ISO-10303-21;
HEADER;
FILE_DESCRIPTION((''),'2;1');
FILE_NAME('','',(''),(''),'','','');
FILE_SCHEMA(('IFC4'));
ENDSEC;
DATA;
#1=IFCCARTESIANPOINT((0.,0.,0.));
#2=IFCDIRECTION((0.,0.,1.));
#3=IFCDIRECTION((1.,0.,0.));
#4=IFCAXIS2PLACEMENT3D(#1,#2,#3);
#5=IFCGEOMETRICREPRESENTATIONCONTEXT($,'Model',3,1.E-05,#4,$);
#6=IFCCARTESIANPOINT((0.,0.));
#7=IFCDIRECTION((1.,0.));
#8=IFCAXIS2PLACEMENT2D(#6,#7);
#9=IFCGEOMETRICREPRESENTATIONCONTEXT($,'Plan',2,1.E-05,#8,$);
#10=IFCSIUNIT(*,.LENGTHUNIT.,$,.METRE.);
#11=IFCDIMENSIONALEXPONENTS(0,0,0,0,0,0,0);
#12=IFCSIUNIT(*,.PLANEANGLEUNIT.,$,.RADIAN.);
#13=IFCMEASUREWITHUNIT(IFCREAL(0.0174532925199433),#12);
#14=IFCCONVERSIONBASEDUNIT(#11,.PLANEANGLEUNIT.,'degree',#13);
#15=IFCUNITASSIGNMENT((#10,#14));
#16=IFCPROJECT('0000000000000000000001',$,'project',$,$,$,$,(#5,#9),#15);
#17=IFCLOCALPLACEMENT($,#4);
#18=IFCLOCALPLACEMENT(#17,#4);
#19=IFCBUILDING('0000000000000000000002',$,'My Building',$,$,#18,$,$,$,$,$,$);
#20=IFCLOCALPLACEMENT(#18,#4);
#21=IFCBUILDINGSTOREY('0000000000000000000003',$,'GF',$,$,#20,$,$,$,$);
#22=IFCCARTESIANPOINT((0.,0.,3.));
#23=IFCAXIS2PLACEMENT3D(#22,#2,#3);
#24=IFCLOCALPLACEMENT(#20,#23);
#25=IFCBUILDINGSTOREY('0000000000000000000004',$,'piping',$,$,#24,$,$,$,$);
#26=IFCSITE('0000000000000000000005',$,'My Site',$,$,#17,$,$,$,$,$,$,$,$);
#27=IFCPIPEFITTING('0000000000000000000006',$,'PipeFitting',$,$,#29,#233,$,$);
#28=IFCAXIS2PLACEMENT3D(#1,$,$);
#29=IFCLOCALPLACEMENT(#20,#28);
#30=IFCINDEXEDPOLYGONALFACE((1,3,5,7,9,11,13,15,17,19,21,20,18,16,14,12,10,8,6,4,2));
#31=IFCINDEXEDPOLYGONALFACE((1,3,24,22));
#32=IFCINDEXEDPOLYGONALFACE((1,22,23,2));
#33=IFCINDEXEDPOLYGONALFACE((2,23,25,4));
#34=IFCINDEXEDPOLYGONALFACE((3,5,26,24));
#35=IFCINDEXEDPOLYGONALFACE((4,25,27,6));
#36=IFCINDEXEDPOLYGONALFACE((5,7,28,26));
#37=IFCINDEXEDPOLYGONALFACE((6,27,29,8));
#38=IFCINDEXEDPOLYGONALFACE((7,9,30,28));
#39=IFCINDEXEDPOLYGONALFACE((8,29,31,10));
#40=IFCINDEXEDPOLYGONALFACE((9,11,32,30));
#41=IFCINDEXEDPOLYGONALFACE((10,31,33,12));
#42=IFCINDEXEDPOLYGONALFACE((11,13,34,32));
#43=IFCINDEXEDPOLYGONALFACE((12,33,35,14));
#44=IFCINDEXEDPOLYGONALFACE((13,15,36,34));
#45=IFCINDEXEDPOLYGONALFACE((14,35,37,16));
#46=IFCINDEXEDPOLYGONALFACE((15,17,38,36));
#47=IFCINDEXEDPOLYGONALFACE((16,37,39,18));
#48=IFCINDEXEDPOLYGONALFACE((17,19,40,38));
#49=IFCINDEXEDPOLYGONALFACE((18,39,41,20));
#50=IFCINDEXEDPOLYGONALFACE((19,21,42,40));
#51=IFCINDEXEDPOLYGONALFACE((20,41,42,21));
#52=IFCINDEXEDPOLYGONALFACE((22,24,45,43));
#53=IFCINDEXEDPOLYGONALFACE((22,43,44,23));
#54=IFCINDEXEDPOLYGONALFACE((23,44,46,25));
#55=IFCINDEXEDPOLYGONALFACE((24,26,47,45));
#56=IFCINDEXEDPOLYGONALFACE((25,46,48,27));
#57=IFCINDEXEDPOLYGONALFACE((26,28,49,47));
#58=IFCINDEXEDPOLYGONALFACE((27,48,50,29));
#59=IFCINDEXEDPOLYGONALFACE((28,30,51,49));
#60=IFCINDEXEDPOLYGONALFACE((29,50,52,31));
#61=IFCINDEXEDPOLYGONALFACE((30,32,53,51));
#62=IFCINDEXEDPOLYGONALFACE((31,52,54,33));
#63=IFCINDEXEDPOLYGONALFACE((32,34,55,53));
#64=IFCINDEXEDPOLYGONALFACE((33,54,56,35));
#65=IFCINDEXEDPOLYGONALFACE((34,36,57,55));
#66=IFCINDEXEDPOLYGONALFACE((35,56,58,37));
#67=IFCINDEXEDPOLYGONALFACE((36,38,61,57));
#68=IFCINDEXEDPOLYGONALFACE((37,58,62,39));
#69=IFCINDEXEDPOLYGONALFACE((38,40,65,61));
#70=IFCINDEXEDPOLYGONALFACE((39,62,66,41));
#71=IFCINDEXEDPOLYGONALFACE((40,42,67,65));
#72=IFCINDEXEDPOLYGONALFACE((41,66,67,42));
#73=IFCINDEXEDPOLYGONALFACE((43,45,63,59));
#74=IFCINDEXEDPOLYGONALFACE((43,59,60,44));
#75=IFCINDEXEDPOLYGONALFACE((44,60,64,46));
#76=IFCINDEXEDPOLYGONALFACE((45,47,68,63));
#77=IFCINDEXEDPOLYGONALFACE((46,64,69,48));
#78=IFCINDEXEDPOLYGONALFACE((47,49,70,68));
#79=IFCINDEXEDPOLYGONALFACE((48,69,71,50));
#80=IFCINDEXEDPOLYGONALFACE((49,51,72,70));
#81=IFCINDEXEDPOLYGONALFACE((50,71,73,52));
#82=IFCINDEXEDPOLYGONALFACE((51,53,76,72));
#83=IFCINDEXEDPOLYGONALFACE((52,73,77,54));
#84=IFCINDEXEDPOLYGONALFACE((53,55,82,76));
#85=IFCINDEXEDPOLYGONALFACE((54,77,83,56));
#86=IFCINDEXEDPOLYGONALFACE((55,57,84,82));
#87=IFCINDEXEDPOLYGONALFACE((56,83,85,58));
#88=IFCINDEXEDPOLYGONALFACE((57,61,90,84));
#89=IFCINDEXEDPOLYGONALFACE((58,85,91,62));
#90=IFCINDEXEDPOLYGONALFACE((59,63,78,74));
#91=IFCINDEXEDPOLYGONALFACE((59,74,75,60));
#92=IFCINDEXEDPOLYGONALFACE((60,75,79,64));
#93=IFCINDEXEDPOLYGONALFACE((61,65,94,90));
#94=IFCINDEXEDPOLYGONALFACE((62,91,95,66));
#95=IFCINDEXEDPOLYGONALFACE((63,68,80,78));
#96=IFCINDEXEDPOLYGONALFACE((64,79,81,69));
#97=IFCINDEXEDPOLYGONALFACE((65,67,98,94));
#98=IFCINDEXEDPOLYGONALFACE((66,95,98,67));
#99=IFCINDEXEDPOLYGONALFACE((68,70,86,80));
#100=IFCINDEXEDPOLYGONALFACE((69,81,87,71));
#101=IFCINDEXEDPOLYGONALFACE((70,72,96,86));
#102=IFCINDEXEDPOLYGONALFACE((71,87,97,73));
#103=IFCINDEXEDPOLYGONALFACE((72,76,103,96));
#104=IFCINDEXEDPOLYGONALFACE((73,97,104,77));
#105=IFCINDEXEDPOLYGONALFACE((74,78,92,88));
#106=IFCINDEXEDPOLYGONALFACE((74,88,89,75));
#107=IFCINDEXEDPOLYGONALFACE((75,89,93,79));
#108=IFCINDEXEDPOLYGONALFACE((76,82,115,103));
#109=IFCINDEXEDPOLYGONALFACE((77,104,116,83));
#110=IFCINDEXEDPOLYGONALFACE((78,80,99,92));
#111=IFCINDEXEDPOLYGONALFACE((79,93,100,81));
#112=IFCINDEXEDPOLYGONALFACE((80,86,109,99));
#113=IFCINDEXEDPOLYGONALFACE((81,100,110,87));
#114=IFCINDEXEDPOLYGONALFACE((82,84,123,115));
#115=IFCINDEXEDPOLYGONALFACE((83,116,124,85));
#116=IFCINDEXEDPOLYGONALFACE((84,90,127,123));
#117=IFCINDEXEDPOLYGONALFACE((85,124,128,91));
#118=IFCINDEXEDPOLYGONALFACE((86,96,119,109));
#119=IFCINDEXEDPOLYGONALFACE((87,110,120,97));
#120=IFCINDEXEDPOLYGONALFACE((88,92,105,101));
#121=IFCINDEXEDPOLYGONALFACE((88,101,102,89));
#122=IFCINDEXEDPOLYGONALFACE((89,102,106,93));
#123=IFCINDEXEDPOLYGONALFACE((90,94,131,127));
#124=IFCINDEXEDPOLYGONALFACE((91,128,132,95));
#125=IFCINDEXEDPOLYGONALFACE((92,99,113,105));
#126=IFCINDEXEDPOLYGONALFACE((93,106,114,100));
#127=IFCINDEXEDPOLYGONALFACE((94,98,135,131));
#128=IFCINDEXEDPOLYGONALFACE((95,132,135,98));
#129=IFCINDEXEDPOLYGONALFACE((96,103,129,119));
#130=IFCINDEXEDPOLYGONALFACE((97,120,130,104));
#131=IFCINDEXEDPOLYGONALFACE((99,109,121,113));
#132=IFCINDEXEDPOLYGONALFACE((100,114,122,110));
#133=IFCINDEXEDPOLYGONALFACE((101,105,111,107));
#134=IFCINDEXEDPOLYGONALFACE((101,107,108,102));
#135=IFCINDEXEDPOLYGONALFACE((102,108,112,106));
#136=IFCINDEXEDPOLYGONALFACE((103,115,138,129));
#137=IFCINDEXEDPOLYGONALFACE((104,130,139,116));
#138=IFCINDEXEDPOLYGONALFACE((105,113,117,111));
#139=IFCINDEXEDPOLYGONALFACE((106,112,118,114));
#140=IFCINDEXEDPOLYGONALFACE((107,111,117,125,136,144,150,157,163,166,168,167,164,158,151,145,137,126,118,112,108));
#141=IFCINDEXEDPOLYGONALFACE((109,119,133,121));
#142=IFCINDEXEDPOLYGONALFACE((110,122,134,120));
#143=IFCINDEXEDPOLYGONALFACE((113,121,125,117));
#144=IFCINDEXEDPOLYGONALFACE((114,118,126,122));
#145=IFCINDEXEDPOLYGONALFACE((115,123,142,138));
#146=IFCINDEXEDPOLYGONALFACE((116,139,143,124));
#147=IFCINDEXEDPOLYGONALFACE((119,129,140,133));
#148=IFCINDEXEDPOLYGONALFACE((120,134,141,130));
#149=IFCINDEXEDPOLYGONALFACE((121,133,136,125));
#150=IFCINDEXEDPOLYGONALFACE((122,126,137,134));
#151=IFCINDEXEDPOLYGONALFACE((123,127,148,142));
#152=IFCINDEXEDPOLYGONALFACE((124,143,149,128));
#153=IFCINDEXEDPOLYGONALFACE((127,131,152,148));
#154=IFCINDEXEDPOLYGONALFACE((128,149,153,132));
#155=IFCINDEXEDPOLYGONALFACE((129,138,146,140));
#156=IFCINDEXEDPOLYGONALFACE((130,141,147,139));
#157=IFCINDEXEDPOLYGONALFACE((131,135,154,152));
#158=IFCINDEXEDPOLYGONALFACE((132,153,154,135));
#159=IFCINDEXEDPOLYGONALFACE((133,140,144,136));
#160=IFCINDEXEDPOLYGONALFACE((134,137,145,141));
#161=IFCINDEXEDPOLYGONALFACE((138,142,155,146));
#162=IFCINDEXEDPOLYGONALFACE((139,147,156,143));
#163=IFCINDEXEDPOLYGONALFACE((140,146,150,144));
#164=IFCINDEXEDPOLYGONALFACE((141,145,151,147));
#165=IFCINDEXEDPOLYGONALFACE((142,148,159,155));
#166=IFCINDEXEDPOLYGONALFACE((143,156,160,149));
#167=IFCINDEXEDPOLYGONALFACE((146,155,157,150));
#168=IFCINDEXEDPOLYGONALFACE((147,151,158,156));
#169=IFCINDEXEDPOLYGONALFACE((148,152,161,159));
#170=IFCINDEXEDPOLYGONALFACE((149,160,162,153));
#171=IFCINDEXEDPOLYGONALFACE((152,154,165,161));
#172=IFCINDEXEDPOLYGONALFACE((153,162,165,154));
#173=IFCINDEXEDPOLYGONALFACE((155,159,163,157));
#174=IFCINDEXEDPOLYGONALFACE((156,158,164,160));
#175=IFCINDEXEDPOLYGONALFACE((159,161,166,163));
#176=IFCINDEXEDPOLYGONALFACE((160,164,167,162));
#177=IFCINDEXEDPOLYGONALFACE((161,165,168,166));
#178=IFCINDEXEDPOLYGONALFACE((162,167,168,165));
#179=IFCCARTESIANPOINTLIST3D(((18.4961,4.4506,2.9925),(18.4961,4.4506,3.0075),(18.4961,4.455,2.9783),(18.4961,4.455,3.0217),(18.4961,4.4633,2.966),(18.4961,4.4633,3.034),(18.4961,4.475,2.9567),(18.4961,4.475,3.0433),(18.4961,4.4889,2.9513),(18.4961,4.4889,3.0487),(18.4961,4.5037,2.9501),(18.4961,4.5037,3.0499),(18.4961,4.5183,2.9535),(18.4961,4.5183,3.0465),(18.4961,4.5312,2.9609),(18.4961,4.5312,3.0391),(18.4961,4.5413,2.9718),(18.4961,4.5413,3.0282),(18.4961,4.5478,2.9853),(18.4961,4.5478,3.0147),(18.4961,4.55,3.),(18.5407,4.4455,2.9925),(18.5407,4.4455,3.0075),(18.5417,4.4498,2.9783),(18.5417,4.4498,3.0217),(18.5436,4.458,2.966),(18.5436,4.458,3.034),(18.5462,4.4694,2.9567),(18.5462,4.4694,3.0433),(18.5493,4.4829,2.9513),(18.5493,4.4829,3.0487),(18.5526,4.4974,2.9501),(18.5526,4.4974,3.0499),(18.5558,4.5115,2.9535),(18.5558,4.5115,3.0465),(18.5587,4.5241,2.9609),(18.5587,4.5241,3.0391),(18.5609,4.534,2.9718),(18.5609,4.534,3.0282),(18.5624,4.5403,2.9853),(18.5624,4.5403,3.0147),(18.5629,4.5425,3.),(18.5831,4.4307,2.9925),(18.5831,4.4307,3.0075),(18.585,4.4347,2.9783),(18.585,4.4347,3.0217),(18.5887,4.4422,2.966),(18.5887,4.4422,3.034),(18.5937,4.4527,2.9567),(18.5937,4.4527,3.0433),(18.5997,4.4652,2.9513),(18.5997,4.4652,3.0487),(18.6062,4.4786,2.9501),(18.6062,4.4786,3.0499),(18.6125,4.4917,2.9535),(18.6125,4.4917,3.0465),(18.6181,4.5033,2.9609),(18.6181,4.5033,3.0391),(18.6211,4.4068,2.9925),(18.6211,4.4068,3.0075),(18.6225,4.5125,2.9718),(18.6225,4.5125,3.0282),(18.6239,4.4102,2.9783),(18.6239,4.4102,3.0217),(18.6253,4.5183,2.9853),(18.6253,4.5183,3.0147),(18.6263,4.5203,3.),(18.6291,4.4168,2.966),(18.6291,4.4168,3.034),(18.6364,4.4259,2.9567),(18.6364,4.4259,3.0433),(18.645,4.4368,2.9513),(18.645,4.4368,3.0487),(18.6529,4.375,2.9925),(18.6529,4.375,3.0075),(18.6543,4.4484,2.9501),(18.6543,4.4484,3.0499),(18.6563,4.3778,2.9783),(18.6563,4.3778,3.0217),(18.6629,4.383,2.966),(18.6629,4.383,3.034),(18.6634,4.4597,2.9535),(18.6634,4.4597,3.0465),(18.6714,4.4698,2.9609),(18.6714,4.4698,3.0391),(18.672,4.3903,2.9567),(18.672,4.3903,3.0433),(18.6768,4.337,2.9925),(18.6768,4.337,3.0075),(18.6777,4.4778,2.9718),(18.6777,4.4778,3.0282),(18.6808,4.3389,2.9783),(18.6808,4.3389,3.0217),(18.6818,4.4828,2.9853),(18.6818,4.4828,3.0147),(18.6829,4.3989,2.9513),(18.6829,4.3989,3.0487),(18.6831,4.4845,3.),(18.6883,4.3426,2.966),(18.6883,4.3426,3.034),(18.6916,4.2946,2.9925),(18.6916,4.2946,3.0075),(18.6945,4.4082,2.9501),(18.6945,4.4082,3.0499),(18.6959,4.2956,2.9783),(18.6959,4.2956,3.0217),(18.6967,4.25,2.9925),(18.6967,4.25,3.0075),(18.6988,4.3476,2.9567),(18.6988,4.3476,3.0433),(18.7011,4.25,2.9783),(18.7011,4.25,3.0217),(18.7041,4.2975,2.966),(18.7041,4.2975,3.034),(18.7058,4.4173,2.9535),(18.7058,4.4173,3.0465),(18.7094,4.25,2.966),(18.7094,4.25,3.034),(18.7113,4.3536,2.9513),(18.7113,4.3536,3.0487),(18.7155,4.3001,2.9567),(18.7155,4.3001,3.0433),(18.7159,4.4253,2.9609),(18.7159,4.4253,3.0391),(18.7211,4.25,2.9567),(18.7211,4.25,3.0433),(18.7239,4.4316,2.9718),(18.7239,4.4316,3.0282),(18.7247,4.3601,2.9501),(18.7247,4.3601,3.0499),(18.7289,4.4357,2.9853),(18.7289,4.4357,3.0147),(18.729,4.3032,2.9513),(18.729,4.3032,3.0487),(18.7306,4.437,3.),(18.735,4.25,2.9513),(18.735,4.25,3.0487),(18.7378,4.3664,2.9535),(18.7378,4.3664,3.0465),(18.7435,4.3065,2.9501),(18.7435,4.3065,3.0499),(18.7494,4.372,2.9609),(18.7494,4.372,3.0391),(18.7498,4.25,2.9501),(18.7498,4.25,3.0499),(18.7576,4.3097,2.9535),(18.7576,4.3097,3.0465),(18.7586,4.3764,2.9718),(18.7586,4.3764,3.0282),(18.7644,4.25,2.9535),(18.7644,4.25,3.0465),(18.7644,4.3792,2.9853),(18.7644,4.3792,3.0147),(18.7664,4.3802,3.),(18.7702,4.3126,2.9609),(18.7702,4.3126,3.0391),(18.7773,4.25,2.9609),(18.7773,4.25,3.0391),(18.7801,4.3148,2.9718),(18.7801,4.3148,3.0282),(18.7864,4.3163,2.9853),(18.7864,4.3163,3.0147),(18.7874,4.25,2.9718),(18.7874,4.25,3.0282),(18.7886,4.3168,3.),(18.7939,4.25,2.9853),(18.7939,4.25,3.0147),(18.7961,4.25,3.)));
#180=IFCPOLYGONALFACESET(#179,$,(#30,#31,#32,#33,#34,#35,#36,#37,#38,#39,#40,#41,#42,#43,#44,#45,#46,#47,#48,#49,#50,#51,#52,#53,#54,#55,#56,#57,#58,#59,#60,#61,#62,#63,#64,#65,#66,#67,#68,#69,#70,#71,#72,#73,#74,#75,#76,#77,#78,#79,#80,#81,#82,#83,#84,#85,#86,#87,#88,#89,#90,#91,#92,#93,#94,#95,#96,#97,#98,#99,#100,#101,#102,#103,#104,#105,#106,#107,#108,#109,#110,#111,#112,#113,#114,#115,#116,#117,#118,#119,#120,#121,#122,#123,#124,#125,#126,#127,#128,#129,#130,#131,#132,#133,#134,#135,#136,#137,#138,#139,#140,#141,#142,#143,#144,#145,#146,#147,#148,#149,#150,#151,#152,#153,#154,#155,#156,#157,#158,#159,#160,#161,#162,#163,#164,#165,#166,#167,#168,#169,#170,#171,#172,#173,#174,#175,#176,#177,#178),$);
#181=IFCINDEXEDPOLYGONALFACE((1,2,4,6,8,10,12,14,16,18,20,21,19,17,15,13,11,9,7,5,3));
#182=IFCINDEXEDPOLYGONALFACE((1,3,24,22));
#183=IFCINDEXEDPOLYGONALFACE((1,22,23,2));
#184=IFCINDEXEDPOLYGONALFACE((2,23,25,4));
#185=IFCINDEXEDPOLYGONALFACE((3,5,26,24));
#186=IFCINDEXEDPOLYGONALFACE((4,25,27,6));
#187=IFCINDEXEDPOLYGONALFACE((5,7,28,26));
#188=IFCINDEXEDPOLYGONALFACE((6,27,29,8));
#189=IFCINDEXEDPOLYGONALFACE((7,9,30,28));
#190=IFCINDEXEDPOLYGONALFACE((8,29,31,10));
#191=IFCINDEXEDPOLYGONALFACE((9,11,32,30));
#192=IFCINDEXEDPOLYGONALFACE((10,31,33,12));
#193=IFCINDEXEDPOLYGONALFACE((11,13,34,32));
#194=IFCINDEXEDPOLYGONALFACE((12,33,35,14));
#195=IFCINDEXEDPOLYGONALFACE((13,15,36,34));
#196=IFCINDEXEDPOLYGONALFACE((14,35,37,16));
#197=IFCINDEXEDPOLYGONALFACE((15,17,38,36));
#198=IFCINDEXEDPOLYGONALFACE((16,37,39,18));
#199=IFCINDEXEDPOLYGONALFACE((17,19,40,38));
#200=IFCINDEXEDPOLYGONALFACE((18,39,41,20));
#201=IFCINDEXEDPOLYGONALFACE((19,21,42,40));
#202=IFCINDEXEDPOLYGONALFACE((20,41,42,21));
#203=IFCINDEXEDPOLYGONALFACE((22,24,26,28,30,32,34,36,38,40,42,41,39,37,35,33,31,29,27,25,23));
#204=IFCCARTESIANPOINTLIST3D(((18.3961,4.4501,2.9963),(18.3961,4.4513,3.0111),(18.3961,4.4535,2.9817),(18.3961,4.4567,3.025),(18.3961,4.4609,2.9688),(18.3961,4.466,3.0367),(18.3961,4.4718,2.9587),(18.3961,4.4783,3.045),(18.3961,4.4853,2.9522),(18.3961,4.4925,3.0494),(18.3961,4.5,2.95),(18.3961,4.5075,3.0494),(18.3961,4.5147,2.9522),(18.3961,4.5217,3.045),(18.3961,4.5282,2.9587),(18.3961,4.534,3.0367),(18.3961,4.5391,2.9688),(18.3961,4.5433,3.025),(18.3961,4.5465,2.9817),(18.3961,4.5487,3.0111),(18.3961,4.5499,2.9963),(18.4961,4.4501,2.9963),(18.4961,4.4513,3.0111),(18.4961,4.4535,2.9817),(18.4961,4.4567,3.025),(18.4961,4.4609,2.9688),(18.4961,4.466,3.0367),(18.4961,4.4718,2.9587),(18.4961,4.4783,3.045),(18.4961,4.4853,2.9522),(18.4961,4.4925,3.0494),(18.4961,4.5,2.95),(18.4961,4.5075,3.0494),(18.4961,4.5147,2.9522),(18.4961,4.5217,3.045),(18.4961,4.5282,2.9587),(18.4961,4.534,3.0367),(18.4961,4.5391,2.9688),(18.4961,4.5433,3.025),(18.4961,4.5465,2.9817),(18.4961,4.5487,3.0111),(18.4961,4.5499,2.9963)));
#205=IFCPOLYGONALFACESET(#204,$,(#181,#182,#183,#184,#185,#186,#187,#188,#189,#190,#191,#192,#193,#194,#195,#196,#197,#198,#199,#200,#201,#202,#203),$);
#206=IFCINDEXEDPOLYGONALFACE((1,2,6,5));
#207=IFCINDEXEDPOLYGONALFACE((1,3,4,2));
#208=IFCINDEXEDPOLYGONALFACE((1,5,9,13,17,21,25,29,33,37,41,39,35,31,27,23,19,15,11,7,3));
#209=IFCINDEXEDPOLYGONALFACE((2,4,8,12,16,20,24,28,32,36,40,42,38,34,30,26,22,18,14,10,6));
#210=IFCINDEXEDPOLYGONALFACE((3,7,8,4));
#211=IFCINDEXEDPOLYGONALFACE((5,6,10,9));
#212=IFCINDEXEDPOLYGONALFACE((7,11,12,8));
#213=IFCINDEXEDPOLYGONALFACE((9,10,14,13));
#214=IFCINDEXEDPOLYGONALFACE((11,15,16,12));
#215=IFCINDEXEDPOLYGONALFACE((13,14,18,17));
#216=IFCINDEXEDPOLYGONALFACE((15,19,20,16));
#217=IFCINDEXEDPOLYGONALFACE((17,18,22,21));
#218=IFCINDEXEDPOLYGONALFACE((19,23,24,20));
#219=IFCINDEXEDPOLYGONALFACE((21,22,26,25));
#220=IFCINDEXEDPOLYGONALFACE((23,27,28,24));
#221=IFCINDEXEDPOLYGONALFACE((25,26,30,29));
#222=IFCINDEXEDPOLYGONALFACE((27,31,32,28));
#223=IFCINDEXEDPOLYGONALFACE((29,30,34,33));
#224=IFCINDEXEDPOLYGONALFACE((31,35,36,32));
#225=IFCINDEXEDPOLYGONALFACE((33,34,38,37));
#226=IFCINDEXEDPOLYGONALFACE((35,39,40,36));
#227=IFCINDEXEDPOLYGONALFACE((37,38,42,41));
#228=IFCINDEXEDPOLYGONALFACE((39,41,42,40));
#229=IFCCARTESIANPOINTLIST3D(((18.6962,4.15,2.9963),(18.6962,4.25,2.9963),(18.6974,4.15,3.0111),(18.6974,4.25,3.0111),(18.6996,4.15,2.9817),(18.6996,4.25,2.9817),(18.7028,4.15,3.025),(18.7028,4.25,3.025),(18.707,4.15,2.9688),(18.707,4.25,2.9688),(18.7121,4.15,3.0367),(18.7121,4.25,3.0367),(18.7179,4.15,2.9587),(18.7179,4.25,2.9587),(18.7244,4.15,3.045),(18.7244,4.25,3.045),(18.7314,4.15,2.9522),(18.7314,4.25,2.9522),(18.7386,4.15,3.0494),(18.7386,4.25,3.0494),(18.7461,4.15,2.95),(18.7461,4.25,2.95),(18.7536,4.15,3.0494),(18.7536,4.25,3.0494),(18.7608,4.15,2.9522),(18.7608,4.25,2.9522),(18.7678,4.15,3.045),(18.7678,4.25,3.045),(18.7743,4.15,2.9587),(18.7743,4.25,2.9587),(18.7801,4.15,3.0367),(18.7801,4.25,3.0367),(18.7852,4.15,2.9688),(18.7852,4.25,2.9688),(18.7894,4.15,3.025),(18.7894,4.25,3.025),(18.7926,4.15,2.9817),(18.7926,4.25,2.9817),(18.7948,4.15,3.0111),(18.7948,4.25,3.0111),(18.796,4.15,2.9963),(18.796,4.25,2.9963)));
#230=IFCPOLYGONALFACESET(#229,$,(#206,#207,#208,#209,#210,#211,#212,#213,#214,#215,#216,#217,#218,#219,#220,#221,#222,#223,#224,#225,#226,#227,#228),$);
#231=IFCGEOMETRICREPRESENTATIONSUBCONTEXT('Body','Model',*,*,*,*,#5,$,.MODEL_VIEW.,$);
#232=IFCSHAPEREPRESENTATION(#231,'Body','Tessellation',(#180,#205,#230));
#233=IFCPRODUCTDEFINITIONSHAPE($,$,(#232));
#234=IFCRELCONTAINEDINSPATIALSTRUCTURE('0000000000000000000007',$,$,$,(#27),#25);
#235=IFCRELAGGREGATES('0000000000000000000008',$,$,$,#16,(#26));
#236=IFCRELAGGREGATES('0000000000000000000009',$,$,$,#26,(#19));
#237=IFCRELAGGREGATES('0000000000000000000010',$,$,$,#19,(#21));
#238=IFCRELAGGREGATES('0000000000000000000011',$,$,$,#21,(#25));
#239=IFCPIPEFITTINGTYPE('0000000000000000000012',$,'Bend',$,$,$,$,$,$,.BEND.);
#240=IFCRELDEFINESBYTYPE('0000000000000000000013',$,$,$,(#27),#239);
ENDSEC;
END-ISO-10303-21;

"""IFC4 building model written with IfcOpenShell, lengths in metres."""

from ifc_helpers import new_model, entity, si_unit, converted_unit, frame, origin_with_axes, origin_2d_with_axis, place, context, subcontext, project, spatial, circle, extrude, source, transform, mapped, type_object, type_shapes, element, save


model = new_model("IFC4")

# Units and contexts
model_context = context("Model", 3, precision=1e-05, world=origin_with_axes())
plan_context = context("Plan", 2, precision=1e-05, world=origin_2d_with_axis())
body_context = subcontext(model_context, "Body", "Model", "MODEL_VIEW")
ifc_project = project(units=[si_unit("LENGTHUNIT", "METRE"), converted_unit("PLANEANGLEUNIT", "degree", entity("IfcReal", 0.0174532925199433), si_unit("PLANEANGLEUNIT", "RADIAN"), dimensions=[0, 0, 0, 0, 0, 0, 0])], contexts=[model_context, plan_context])

# Site, building, storeys
site_placement = place(None, origin_with_axes())
site = spatial("IfcSite", under=ifc_project, at=site_placement, Name="My Site")
building_placement = place(site_placement, origin_with_axes())
building = spatial("IfcBuilding", under=site, at=building_placement, Name="My Building")
storey_1_placement = place(building_placement, origin_with_axes())
storey_1 = spatial("IfcBuildingStorey", under=building, at=storey_1_placement, Name="GF")
storey_2_placement = place(storey_1_placement, frame((0.0, 0.0, 3.0), z_axis=(0.0, 0.0, 1.0), x_axis=(1.0, 0.0, 0.0)))
storey_2 = spatial("IfcBuildingStorey", under=storey_1, at=storey_2_placement, Name="piping")

# Pipe fitting
pipe_fitting_type = type_object("IfcPipeFittingType", Name="Bend", PredefinedType="BEND")
shared_shape = source(origin_with_axes(), body_context, "Body", "SolidModel", [
    entity("IfcSweptDiskSolid", entity("IfcIndexedPolyCurve", entity("IfcCartesianPointList3D", [[0.0, 0.0, -0.1], [0.0, 0.0732, -0.2768], [0.0, 0.25, -0.35]]), [entity("IfcArcIndex", [1, 2, 3])]), 0.05),
    extrude(circle(Radius=0.05), origin_with_axes(), (0.0, 0.0, -1.0), 0.1),
    extrude(circle(Radius=0.05), frame((0.0, 0.25, -0.35), z_axis=(0.0, 1.0, 0.0), x_axis=(1.0, 0.0, 0.0)), (0.0, 0.0, 1.0), 0.1),
])
type_shapes(pipe_fitting_type, [shared_shape])
for number, where, z_axis, x_axis, name in (
    (1, (18.3961, 4.5, 0.0), (-1.0, 0.0, 0.0), (0.0, 0.0, -1.0), "PipeFitting"),
):
    element("IfcPipeFitting", number, at=place(storey_2_placement, frame(where, z_axis=z_axis, x_axis=x_axis)), inside=storey_2, type_object=pipe_fitting_type, Name=name, context=body_context, shape_type="MappedRepresentation", body=[
        mapped(shared_shape, transform((0.0, 0.0, 0.0), x_axis=(1.0, 0.0, 0.0), y_axis=(0.0, 1.0, 0.0), z_axis=(0.0, 0.0, 1.0), scale=1.0)),
    ])

save(model, "model.ifc")
